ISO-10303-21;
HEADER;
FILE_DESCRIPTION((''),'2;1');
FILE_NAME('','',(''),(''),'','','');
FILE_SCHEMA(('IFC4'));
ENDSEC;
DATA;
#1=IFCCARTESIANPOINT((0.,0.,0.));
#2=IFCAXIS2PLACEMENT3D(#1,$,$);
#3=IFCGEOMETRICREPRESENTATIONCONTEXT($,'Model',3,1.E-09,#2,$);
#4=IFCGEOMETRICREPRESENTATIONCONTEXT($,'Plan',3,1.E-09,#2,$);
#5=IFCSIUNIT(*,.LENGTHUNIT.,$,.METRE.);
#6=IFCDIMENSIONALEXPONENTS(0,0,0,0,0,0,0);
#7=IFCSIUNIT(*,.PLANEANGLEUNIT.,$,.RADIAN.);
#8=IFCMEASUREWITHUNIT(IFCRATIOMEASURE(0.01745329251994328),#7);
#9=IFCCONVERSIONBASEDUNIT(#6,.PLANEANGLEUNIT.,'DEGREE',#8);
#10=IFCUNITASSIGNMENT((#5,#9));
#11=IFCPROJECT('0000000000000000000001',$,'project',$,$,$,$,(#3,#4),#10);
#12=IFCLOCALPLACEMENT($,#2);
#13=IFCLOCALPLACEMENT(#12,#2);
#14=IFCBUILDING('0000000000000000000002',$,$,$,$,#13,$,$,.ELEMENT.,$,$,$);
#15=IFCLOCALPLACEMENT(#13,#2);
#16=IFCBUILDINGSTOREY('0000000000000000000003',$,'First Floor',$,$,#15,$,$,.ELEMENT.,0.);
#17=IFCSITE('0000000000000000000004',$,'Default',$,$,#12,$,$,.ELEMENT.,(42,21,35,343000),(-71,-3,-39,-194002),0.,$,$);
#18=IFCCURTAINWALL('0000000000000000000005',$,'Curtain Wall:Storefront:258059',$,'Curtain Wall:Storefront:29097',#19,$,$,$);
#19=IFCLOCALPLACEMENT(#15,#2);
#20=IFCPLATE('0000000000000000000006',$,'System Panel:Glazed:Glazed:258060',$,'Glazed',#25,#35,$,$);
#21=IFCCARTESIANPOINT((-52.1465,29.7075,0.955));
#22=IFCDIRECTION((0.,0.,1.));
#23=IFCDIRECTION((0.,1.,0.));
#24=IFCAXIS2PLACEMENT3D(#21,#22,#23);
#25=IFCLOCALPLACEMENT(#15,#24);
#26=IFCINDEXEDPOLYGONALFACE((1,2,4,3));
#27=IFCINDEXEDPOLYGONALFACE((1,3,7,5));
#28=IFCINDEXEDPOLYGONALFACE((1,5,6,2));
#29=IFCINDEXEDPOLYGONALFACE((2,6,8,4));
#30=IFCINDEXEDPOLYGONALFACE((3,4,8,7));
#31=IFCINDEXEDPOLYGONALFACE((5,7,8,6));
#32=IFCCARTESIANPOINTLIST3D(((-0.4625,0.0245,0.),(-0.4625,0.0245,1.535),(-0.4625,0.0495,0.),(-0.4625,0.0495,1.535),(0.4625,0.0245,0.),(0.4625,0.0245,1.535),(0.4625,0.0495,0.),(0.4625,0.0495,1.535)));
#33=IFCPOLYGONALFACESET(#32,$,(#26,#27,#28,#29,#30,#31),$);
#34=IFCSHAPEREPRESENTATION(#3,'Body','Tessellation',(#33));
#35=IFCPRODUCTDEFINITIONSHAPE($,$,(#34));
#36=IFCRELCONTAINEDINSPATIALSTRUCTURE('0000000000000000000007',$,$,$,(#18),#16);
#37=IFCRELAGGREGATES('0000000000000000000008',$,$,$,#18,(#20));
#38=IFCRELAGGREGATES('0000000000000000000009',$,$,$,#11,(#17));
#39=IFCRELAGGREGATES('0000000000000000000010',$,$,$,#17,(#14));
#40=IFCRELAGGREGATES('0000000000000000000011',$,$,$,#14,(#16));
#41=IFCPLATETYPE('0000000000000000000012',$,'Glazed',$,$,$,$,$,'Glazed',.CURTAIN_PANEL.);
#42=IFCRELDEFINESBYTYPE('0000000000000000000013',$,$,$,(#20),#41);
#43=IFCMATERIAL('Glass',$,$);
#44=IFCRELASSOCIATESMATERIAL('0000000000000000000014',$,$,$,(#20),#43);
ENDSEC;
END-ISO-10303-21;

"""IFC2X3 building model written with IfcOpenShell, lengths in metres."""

from ifc_helpers import new_model, entity, si_unit, converted_unit, frame, origin, origin_2d_with_axis, place, context, project, spatial, rectangle, extrude, source, transform, mapped, material, type_object, type_shapes, element, aggregate, save


model = new_model("IFC2X3")

# Units and contexts
model_context = context("Model", 3, precision=1e-09, world=origin())
plan_context = context("Plan", 3, precision=1e-09, world=origin())
ifc_project = project(units=[si_unit("LENGTHUNIT", "METRE"), converted_unit("PLANEANGLEUNIT", "DEGREE", entity("IfcRatioMeasure", 0.01745329251994328), si_unit("PLANEANGLEUNIT", "RADIAN"), dimensions=[0, 0, 0, 0, 0, 0, 0])], contexts=[model_context, plan_context])

# Site, building, storey
site_placement = place(None, origin())
site = spatial("IfcSite", under=ifc_project, at=site_placement, Name="Default", CompositionType="ELEMENT", RefLatitude=(42, 21, 35, 343000), RefLongitude=(-71, -3, -39, -194002), RefElevation=0.0)
building_placement = place(site_placement, origin())
building = spatial("IfcBuilding", under=site, at=building_placement, CompositionType="ELEMENT")
storey_placement = place(building_placement, origin())
storey = spatial("IfcBuildingStorey", under=building, at=storey_placement, Name="First Floor", CompositionType="ELEMENT", Elevation=0.0)

# Curtain wall, plate
curtain_wall_placement = place(storey_placement, origin())
curtain_wall = element("IfcCurtainWall", 1, at=curtain_wall_placement, inside=storey, Name="Curtain Wall:Storefront:258059", ObjectType="Curtain Wall:Storefront:29097")
ifc_material_1 = material(Name="Glass")
plate_type = type_object("IfcPlateType", Name="Glazed", ElementType="Glazed", PredefinedType="CURTAIN_PANEL")
shared_shape_1 = source(origin(), model_context, "Body", "SweptSolid", [
    extrude(rectangle(XDim=0.025, YDim=0.925, at=origin_2d_with_axis()), frame((0.0, 0.037, 0.0), z_axis=(0.0, 0.0, 1.0), x_axis=(0.0, 1.0, 0.0)), (0.0, 0.0, 1.0), 1.535),
])
type_shapes(plate_type, [shared_shape_1])
plate_placement = place(storey_placement, frame((-52.1465, 29.7075, 0.955), z_axis=(0.0, 0.0, 1.0), x_axis=(0.0, 1.0, 0.0)))
plate = element("IfcPlate", 2, at=plate_placement, type_object=plate_type, material=ifc_material_1, Name="System Panel:Glazed:Glazed:258060", ObjectType="Glazed", context=model_context, shape_type="MappedRepresentation", body=[
    mapped(shared_shape_1, transform((0.0, 0.0, 0.0), scale=1.0)),
])
aggregate(curtain_wall, [plate])

save(model, "model.ifc")
